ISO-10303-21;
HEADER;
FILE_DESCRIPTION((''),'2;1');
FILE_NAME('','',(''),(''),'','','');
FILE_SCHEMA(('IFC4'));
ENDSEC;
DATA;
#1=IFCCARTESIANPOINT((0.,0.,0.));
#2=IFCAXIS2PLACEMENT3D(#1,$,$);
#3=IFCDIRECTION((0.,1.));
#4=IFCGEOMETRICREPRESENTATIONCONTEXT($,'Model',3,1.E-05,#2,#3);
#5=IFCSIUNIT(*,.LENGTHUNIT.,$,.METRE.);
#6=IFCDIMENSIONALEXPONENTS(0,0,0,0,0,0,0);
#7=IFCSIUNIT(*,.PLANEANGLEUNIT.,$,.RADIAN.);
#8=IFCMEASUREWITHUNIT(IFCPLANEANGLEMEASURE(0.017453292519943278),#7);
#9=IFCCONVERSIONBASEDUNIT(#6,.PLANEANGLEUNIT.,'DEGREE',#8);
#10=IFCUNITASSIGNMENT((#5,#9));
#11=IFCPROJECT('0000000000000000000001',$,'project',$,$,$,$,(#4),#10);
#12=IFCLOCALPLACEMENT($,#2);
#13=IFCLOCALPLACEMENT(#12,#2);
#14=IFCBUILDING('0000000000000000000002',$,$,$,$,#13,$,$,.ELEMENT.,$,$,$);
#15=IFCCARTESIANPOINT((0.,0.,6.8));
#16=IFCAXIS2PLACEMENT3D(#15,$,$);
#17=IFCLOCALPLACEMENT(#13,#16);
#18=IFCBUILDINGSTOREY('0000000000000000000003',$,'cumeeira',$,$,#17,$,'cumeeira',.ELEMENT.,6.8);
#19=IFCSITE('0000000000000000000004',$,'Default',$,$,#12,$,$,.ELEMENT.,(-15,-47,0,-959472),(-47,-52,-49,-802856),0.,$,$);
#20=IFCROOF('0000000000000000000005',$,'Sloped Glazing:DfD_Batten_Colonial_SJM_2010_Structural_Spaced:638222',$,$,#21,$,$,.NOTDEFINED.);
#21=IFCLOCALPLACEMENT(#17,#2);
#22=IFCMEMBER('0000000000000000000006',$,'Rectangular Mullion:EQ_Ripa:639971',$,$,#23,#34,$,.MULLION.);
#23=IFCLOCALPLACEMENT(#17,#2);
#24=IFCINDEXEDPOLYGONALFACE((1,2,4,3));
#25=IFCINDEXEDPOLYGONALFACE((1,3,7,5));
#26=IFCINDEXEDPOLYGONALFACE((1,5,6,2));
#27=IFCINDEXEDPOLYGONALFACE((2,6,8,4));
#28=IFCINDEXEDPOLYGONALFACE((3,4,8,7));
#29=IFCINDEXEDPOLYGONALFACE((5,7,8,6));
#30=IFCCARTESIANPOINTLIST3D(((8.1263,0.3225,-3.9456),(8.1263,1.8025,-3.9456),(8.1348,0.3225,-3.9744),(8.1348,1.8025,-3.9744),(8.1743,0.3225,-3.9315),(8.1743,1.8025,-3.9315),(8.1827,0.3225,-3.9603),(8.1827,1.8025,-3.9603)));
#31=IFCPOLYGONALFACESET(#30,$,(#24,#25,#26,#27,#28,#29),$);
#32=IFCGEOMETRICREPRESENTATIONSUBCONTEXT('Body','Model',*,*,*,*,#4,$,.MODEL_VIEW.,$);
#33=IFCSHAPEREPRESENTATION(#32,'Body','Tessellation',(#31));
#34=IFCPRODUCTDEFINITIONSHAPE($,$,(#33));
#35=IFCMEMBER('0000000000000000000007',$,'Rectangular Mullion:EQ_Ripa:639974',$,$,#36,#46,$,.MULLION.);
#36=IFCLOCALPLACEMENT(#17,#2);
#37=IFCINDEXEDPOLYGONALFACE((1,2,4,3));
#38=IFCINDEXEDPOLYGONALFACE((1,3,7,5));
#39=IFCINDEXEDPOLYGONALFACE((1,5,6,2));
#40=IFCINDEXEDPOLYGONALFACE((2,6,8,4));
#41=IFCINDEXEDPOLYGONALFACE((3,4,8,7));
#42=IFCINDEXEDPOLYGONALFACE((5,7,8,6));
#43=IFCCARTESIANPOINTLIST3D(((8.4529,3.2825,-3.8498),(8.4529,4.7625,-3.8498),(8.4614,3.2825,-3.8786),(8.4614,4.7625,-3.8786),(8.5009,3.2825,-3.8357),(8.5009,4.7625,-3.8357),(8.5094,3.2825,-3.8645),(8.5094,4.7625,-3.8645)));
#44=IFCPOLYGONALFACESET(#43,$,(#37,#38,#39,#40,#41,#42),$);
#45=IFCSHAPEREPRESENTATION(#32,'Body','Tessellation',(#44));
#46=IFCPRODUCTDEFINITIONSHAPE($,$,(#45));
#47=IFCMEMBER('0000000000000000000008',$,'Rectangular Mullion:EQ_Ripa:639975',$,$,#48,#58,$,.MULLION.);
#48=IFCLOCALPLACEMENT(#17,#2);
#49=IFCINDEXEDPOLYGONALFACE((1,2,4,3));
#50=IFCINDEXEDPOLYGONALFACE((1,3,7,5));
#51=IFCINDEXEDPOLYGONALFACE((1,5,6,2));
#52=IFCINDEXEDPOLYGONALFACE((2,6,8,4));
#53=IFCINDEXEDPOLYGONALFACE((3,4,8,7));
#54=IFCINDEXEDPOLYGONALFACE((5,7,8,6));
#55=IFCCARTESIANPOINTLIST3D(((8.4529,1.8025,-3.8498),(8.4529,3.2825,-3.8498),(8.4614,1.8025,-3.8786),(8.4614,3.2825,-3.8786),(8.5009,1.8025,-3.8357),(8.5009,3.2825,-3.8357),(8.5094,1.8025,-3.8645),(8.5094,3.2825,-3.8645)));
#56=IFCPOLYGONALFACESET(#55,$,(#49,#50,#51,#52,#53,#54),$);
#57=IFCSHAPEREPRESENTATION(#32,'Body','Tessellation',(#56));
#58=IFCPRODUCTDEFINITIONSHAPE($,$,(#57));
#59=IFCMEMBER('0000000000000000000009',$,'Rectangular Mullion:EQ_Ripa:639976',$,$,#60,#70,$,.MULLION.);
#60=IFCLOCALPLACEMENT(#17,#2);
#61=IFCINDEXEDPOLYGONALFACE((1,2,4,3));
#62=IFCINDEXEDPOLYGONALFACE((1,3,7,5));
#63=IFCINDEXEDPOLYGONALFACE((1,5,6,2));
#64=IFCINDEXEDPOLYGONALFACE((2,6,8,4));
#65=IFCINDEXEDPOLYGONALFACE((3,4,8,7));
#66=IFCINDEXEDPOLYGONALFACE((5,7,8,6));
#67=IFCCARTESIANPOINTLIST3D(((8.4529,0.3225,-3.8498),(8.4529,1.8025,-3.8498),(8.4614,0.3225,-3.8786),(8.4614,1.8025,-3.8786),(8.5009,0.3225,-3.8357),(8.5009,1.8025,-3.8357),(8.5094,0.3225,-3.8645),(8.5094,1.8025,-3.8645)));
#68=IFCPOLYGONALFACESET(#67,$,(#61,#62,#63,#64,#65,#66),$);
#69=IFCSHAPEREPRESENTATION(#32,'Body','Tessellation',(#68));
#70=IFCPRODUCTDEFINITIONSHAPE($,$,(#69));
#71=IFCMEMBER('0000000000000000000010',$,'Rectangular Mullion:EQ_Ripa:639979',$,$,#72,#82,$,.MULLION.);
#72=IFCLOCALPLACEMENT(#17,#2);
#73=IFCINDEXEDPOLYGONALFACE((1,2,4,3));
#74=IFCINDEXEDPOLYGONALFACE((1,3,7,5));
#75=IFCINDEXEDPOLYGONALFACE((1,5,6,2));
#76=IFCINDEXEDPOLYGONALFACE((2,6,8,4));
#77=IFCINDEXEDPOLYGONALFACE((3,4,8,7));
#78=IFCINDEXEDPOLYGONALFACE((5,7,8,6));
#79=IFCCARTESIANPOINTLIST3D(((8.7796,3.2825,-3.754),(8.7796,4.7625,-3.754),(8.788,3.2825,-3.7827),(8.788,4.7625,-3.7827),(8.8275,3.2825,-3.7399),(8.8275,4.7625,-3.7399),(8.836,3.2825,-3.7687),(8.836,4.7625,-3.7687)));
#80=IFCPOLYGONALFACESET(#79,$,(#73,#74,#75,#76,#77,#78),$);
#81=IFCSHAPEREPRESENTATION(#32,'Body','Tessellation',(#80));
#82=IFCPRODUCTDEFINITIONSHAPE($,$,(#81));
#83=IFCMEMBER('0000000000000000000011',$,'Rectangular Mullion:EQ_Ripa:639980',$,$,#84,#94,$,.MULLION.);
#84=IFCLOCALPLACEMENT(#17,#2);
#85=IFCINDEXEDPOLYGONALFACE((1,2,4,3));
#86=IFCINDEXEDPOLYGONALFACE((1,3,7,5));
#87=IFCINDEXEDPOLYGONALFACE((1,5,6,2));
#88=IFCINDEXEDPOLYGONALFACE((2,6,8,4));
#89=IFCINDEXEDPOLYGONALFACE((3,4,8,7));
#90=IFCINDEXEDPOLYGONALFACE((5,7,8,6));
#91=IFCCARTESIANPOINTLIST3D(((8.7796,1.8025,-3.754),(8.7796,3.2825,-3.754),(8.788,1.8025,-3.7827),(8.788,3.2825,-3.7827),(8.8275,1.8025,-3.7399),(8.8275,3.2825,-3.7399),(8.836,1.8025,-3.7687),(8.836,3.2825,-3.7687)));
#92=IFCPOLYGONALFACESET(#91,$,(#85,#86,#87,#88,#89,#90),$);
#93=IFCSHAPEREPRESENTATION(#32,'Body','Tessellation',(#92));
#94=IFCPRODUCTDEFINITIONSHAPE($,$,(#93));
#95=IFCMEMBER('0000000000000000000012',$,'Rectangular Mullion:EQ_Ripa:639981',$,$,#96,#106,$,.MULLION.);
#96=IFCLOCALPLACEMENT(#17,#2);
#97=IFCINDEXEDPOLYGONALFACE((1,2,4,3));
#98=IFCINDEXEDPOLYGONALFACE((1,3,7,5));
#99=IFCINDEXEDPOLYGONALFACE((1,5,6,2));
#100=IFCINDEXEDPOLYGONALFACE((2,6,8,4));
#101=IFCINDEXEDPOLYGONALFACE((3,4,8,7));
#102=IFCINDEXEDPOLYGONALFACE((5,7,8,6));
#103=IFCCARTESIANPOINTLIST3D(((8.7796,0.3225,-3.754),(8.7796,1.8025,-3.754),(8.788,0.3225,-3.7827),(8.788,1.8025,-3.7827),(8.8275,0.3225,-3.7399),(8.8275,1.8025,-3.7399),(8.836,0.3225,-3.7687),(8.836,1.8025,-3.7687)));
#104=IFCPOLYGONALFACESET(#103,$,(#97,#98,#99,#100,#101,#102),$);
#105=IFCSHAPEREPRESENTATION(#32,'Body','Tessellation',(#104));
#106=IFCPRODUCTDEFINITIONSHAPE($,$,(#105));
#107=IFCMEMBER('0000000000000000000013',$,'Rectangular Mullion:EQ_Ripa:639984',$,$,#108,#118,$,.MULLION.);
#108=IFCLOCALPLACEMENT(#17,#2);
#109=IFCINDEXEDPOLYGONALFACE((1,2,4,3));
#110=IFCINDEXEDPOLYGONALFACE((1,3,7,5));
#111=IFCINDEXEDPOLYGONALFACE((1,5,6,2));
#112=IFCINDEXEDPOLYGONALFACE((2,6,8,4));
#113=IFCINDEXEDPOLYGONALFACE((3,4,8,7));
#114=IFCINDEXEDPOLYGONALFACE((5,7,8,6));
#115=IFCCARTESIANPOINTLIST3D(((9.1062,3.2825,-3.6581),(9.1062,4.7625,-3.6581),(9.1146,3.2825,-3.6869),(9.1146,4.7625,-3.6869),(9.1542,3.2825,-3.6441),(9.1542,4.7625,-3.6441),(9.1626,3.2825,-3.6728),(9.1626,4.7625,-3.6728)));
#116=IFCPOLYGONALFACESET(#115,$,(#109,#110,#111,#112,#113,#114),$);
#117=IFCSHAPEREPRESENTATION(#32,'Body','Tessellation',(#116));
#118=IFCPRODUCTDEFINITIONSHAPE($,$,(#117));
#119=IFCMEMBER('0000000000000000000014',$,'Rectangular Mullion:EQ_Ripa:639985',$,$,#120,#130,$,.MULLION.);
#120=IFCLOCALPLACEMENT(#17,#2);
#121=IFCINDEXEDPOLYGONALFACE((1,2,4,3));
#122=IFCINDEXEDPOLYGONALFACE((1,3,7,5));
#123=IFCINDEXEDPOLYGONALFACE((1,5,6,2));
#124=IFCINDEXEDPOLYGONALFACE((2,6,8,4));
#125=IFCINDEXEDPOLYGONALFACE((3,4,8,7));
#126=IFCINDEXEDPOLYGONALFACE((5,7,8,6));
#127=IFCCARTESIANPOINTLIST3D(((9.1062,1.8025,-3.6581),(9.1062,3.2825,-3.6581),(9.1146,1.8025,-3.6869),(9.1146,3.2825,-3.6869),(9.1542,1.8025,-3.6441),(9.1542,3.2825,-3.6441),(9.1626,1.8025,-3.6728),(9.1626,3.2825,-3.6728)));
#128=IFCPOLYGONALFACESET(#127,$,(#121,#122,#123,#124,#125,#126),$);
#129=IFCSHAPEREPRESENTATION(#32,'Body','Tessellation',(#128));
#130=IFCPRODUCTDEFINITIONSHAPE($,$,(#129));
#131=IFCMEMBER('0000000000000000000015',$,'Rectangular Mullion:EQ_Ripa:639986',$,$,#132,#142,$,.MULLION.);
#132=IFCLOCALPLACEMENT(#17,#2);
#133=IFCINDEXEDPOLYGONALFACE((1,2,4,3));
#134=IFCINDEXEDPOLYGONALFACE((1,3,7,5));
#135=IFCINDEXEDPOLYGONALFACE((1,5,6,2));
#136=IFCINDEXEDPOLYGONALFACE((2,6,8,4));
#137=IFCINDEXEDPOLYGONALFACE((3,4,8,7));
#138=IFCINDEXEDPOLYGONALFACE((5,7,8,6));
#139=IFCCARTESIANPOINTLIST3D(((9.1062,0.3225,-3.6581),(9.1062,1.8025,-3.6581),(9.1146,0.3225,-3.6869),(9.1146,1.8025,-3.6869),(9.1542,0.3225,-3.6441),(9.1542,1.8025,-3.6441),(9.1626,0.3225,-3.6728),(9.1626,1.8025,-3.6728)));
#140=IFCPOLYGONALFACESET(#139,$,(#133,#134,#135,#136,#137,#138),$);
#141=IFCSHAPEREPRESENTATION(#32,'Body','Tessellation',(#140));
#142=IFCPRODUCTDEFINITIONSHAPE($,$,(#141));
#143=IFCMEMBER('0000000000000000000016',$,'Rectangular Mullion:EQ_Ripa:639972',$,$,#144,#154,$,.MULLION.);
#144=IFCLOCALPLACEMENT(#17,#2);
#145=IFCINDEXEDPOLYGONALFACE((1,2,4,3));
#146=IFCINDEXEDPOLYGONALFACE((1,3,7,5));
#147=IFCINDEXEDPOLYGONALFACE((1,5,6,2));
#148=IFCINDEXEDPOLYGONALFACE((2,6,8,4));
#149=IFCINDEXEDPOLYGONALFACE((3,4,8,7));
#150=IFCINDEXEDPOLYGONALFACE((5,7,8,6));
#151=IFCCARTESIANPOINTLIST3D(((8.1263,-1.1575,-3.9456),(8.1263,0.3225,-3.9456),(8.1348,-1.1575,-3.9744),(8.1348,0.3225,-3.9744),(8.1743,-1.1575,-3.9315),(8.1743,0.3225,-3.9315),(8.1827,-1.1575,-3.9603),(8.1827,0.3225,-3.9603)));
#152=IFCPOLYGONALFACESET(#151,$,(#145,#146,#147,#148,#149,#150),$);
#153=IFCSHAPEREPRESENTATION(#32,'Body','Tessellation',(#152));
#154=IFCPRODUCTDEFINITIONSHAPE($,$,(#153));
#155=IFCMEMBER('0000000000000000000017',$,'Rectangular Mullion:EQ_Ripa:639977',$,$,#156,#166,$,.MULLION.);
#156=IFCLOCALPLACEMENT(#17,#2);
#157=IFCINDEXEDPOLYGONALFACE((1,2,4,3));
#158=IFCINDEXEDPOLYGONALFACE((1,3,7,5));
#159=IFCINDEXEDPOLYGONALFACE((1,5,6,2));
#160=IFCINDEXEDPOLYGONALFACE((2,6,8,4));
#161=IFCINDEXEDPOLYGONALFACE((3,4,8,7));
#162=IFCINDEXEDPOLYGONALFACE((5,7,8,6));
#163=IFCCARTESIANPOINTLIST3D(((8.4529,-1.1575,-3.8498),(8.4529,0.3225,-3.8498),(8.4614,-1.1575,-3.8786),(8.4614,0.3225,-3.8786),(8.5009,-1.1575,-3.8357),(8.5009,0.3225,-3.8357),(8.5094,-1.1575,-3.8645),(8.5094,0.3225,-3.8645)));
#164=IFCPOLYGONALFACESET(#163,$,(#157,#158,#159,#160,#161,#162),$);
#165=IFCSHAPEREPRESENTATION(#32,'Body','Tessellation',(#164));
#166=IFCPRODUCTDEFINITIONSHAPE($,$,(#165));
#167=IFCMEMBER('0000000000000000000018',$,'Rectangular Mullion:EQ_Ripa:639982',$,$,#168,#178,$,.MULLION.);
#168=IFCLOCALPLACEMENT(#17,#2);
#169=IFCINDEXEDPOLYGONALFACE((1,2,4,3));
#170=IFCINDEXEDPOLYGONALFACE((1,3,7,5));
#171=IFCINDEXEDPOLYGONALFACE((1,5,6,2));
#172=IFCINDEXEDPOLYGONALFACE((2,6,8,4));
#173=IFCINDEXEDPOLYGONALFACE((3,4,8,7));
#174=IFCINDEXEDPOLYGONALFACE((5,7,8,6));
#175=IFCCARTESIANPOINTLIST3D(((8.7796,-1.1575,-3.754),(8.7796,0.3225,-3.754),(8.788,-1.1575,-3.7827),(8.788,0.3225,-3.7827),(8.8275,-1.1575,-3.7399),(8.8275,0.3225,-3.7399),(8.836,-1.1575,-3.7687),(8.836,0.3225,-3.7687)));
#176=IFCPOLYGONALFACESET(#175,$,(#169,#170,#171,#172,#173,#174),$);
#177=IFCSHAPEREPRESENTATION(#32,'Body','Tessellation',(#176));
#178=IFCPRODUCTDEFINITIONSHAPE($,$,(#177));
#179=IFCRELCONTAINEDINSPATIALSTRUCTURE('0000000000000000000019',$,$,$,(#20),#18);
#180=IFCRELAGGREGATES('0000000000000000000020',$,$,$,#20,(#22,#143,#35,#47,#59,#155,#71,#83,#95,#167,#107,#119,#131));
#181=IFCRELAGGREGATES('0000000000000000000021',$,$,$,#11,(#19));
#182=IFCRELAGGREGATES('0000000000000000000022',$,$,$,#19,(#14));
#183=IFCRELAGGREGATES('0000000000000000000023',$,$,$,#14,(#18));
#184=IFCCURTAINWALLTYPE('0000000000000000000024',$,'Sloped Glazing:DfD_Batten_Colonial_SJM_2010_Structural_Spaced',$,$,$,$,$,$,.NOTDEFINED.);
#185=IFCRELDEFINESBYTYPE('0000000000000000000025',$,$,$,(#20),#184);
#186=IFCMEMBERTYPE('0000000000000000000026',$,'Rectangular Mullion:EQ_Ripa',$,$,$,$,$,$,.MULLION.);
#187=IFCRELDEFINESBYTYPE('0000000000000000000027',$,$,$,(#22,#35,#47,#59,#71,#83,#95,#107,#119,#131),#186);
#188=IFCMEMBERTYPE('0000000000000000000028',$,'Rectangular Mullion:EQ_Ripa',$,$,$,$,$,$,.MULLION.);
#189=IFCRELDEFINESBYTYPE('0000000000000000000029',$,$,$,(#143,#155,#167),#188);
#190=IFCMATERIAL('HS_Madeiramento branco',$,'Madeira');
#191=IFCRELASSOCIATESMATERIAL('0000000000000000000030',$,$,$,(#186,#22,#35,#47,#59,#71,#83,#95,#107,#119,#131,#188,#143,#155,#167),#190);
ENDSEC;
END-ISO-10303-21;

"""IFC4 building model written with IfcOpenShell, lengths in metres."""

from ifc_helpers import new_model, entity, si_unit, converted_unit, direction, frame, origin, place, context, subcontext, project, spatial, indexed_curve, outline, extrude, source, transform, mapped, material, type_object, type_shapes, element, aggregate, save


model = new_model("IFC4")

# Units and contexts
model_context = context("Model", 3, precision=1e-05, world=origin(), true_north=direction((0.0, 1.0)))
body_context = subcontext(model_context, "Body", "Model", "MODEL_VIEW")
ifc_project = project(units=[si_unit("LENGTHUNIT", "METRE"), converted_unit("PLANEANGLEUNIT", "DEGREE", entity("IfcPlaneAngleMeasure", 0.017453292519943278), si_unit("PLANEANGLEUNIT", "RADIAN"), dimensions=[0, 0, 0, 0, 0, 0, 0])], contexts=[model_context])

# Site, building, storey
site_placement = place(None, origin())
site = spatial("IfcSite", under=ifc_project, at=site_placement, Name="Default", CompositionType="ELEMENT", RefLatitude=(-15, -47, 0, -959472), RefLongitude=(-47, -52, -49, -802856), RefElevation=0.0)
building_placement = place(site_placement, origin())
building = spatial("IfcBuilding", under=site, at=building_placement, CompositionType="ELEMENT")
storey_placement = place(building_placement, frame((0.0, 0.0, 6.8)))
storey = spatial("IfcBuildingStorey", under=building, at=storey_placement, Name="cumeeira", LongName="cumeeira", CompositionType="ELEMENT", Elevation=6.8)

# Roof, members
curtain_wall_type = type_object("IfcCurtainWallType", Name="Sloped Glazing:DfD_Batten_Colonial_SJM_2010_Structural_Spaced", PredefinedType="NOTDEFINED")
roof_placement = place(storey_placement, frame((0.0, 0.0, -6.8)))
roof = element("IfcRoof", 1, at=roof_placement, inside=storey, type_object=curtain_wall_type, Name="Sloped Glazing:DfD_Batten_Colonial_SJM_2010_Structural_Spaced:638222", PredefinedType="NOTDEFINED")
ifc_material = material(Name="HS_Madeiramento branco", Category="Madeira")
member_type_1 = type_object("IfcMemberType", Name="Rectangular Mullion:EQ_Ripa", PredefinedType="MULLION", material=ifc_material)
shared_shape_1 = source(origin(), body_context, "Body", "SweptSolid", [
    extrude(outline(indexed_curve([(-0.025, -0.015), (0.025, -0.015), (0.025, 0.015), (-0.025, 0.015), (-0.025, -0.015)], self_intersect=False)), frame((0.0, 0.0, -1.48), z_axis=(0.0, 0.0, 1.0), x_axis=(-1.0, 0.0, 0.0)), (0.0, 0.0, 1.0), 1.48),
])
type_shapes(member_type_1, [shared_shape_1])
member_1_placement = place(roof_placement, frame((8.1545, 1.8025, 2.847), z_axis=(0.0, 1.0, 0.0), x_axis=(0.95956, 0.0, 0.281504)))
member_1 = element("IfcMember", 2, at=member_1_placement, type_object=member_type_1, material=ifc_material, Name="Rectangular Mullion:EQ_Ripa:639971", PredefinedType="MULLION", context=body_context, shape_type="MappedRepresentation", body=[
    mapped(shared_shape_1, transform((0.0, 0.0, 0.0), scale=1.0)),
])
member_2_placement = place(roof_placement, frame((8.4812, 4.7625, 2.9429), z_axis=(0.0, 1.0, 0.0), x_axis=(0.95956, 0.0, 0.281504)))
member_2 = element("IfcMember", 3, at=member_2_placement, type_object=member_type_1, material=ifc_material, Name="Rectangular Mullion:EQ_Ripa:639974", PredefinedType="MULLION", context=body_context, shape_type="MappedRepresentation", body=[
    mapped(shared_shape_1, transform((0.0, 0.0, 0.0), scale=1.0)),
])
member_3_placement = place(roof_placement, frame((8.4812, 3.2825, 2.9429), z_axis=(0.0, 1.0, 0.0), x_axis=(0.95956, 0.0, 0.281504)))
member_3 = element("IfcMember", 4, at=member_3_placement, type_object=member_type_1, material=ifc_material, Name="Rectangular Mullion:EQ_Ripa:639975", PredefinedType="MULLION", context=body_context, shape_type="MappedRepresentation", body=[
    mapped(shared_shape_1, transform((0.0, 0.0, 0.0), scale=1.0)),
])
member_4_placement = place(roof_placement, frame((8.4812, 1.8025, 2.9429), z_axis=(0.0, 1.0, 0.0), x_axis=(0.95956, 0.0, 0.281504)))
member_4 = element("IfcMember", 5, at=member_4_placement, type_object=member_type_1, material=ifc_material, Name="Rectangular Mullion:EQ_Ripa:639976", PredefinedType="MULLION", context=body_context, shape_type="MappedRepresentation", body=[
    mapped(shared_shape_1, transform((0.0, 0.0, 0.0), scale=1.0)),
])
member_5_placement = place(roof_placement, frame((8.8078, 4.7625, 3.0387), z_axis=(0.0, 1.0, 0.0), x_axis=(0.95956, 0.0, 0.281504)))
member_5 = element("IfcMember", 6, at=member_5_placement, type_object=member_type_1, material=ifc_material, Name="Rectangular Mullion:EQ_Ripa:639979", PredefinedType="MULLION", context=body_context, shape_type="MappedRepresentation", body=[
    mapped(shared_shape_1, transform((0.0, 0.0, 0.0), scale=1.0)),
])
member_6_placement = place(roof_placement, frame((8.8078, 3.2825, 3.0387), z_axis=(0.0, 1.0, 0.0), x_axis=(0.95956, 0.0, 0.281504)))
member_6 = element("IfcMember", 7, at=member_6_placement, type_object=member_type_1, material=ifc_material, Name="Rectangular Mullion:EQ_Ripa:639980", PredefinedType="MULLION", context=body_context, shape_type="MappedRepresentation", body=[
    mapped(shared_shape_1, transform((0.0, 0.0, 0.0), scale=1.0)),
])
member_7_placement = place(roof_placement, frame((8.8078, 1.8025, 3.0387), z_axis=(0.0, 1.0, 0.0), x_axis=(0.95956, 0.0, 0.281504)))
member_7 = element("IfcMember", 8, at=member_7_placement, type_object=member_type_1, material=ifc_material, Name="Rectangular Mullion:EQ_Ripa:639981", PredefinedType="MULLION", context=body_context, shape_type="MappedRepresentation", body=[
    mapped(shared_shape_1, transform((0.0, 0.0, 0.0), scale=1.0)),
])
member_8_placement = place(roof_placement, frame((9.1344, 4.7625, 3.1345), z_axis=(0.0, 1.0, 0.0), x_axis=(0.95956, 0.0, 0.281504)))
member_8 = element("IfcMember", 9, at=member_8_placement, type_object=member_type_1, material=ifc_material, Name="Rectangular Mullion:EQ_Ripa:639984", PredefinedType="MULLION", context=body_context, shape_type="MappedRepresentation", body=[
    mapped(shared_shape_1, transform((0.0, 0.0, 0.0), scale=1.0)),
])
member_9_placement = place(roof_placement, frame((9.1344, 3.2825, 3.1345), z_axis=(0.0, 1.0, 0.0), x_axis=(0.95956, 0.0, 0.281504)))
member_9 = element("IfcMember", 10, at=member_9_placement, type_object=member_type_1, material=ifc_material, Name="Rectangular Mullion:EQ_Ripa:639985", PredefinedType="MULLION", context=body_context, shape_type="MappedRepresentation", body=[
    mapped(shared_shape_1, transform((0.0, 0.0, 0.0), scale=1.0)),
])
member_10_placement = place(roof_placement, frame((9.1344, 1.8025, 3.1345), z_axis=(0.0, 1.0, 0.0), x_axis=(0.95956, 0.0, 0.281504)))
member_10 = element("IfcMember", 11, at=member_10_placement, type_object=member_type_1, material=ifc_material, Name="Rectangular Mullion:EQ_Ripa:639986", PredefinedType="MULLION", context=body_context, shape_type="MappedRepresentation", body=[
    mapped(shared_shape_1, transform((0.0, 0.0, 0.0), scale=1.0)),
])
member_type_2 = type_object("IfcMemberType", Name="Rectangular Mullion:EQ_Ripa", PredefinedType="MULLION", material=ifc_material)
shared_shape_2 = source(origin(), body_context, "Body", "SweptSolid", [
    extrude(outline(indexed_curve([(-0.025, -0.015), (0.025, -0.015), (0.025, 0.015), (-0.025, 0.015), (-0.025, -0.015)], self_intersect=False)), frame((0.0, 0.0, -1.48), z_axis=(0.0, 0.0, 1.0), x_axis=(-1.0, 0.0, 0.0)), (0.0, 0.0, 1.0), 1.48),
])
type_shapes(member_type_2, [shared_shape_2])
member_11_placement = place(roof_placement, frame((8.1545, 0.3225, 2.847), z_axis=(0.0, 1.0, 0.0), x_axis=(0.95956, 0.0, 0.281504)))
member_11 = element("IfcMember", 12, at=member_11_placement, type_object=member_type_2, material=ifc_material, Name="Rectangular Mullion:EQ_Ripa:639972", PredefinedType="MULLION", context=body_context, shape_type="MappedRepresentation", body=[
    mapped(shared_shape_2, transform((0.0, 0.0, 0.0), scale=1.0)),
])
member_12_placement = place(roof_placement, frame((8.4812, 0.3225, 2.9429), z_axis=(0.0, 1.0, 0.0), x_axis=(0.95956, 0.0, 0.281504)))
member_12 = element("IfcMember", 13, at=member_12_placement, type_object=member_type_2, material=ifc_material, Name="Rectangular Mullion:EQ_Ripa:639977", PredefinedType="MULLION", context=body_context, shape_type="MappedRepresentation", body=[
    mapped(shared_shape_2, transform((0.0, 0.0, 0.0), scale=1.0)),
])
member_13_placement = place(roof_placement, frame((8.8078, 0.3225, 3.0387), z_axis=(0.0, 1.0, 0.0), x_axis=(0.95956, 0.0, 0.281504)))
member_13 = element("IfcMember", 14, at=member_13_placement, type_object=member_type_2, material=ifc_material, Name="Rectangular Mullion:EQ_Ripa:639982", PredefinedType="MULLION", context=body_context, shape_type="MappedRepresentation", body=[
    mapped(shared_shape_2, transform((0.0, 0.0, 0.0), scale=1.0)),
])
aggregate(roof, [member_1, member_11, member_2, member_3, member_4, member_12, member_5, member_6, member_7, member_13, member_8, member_9, member_10])

save(model, "model.ifc")
